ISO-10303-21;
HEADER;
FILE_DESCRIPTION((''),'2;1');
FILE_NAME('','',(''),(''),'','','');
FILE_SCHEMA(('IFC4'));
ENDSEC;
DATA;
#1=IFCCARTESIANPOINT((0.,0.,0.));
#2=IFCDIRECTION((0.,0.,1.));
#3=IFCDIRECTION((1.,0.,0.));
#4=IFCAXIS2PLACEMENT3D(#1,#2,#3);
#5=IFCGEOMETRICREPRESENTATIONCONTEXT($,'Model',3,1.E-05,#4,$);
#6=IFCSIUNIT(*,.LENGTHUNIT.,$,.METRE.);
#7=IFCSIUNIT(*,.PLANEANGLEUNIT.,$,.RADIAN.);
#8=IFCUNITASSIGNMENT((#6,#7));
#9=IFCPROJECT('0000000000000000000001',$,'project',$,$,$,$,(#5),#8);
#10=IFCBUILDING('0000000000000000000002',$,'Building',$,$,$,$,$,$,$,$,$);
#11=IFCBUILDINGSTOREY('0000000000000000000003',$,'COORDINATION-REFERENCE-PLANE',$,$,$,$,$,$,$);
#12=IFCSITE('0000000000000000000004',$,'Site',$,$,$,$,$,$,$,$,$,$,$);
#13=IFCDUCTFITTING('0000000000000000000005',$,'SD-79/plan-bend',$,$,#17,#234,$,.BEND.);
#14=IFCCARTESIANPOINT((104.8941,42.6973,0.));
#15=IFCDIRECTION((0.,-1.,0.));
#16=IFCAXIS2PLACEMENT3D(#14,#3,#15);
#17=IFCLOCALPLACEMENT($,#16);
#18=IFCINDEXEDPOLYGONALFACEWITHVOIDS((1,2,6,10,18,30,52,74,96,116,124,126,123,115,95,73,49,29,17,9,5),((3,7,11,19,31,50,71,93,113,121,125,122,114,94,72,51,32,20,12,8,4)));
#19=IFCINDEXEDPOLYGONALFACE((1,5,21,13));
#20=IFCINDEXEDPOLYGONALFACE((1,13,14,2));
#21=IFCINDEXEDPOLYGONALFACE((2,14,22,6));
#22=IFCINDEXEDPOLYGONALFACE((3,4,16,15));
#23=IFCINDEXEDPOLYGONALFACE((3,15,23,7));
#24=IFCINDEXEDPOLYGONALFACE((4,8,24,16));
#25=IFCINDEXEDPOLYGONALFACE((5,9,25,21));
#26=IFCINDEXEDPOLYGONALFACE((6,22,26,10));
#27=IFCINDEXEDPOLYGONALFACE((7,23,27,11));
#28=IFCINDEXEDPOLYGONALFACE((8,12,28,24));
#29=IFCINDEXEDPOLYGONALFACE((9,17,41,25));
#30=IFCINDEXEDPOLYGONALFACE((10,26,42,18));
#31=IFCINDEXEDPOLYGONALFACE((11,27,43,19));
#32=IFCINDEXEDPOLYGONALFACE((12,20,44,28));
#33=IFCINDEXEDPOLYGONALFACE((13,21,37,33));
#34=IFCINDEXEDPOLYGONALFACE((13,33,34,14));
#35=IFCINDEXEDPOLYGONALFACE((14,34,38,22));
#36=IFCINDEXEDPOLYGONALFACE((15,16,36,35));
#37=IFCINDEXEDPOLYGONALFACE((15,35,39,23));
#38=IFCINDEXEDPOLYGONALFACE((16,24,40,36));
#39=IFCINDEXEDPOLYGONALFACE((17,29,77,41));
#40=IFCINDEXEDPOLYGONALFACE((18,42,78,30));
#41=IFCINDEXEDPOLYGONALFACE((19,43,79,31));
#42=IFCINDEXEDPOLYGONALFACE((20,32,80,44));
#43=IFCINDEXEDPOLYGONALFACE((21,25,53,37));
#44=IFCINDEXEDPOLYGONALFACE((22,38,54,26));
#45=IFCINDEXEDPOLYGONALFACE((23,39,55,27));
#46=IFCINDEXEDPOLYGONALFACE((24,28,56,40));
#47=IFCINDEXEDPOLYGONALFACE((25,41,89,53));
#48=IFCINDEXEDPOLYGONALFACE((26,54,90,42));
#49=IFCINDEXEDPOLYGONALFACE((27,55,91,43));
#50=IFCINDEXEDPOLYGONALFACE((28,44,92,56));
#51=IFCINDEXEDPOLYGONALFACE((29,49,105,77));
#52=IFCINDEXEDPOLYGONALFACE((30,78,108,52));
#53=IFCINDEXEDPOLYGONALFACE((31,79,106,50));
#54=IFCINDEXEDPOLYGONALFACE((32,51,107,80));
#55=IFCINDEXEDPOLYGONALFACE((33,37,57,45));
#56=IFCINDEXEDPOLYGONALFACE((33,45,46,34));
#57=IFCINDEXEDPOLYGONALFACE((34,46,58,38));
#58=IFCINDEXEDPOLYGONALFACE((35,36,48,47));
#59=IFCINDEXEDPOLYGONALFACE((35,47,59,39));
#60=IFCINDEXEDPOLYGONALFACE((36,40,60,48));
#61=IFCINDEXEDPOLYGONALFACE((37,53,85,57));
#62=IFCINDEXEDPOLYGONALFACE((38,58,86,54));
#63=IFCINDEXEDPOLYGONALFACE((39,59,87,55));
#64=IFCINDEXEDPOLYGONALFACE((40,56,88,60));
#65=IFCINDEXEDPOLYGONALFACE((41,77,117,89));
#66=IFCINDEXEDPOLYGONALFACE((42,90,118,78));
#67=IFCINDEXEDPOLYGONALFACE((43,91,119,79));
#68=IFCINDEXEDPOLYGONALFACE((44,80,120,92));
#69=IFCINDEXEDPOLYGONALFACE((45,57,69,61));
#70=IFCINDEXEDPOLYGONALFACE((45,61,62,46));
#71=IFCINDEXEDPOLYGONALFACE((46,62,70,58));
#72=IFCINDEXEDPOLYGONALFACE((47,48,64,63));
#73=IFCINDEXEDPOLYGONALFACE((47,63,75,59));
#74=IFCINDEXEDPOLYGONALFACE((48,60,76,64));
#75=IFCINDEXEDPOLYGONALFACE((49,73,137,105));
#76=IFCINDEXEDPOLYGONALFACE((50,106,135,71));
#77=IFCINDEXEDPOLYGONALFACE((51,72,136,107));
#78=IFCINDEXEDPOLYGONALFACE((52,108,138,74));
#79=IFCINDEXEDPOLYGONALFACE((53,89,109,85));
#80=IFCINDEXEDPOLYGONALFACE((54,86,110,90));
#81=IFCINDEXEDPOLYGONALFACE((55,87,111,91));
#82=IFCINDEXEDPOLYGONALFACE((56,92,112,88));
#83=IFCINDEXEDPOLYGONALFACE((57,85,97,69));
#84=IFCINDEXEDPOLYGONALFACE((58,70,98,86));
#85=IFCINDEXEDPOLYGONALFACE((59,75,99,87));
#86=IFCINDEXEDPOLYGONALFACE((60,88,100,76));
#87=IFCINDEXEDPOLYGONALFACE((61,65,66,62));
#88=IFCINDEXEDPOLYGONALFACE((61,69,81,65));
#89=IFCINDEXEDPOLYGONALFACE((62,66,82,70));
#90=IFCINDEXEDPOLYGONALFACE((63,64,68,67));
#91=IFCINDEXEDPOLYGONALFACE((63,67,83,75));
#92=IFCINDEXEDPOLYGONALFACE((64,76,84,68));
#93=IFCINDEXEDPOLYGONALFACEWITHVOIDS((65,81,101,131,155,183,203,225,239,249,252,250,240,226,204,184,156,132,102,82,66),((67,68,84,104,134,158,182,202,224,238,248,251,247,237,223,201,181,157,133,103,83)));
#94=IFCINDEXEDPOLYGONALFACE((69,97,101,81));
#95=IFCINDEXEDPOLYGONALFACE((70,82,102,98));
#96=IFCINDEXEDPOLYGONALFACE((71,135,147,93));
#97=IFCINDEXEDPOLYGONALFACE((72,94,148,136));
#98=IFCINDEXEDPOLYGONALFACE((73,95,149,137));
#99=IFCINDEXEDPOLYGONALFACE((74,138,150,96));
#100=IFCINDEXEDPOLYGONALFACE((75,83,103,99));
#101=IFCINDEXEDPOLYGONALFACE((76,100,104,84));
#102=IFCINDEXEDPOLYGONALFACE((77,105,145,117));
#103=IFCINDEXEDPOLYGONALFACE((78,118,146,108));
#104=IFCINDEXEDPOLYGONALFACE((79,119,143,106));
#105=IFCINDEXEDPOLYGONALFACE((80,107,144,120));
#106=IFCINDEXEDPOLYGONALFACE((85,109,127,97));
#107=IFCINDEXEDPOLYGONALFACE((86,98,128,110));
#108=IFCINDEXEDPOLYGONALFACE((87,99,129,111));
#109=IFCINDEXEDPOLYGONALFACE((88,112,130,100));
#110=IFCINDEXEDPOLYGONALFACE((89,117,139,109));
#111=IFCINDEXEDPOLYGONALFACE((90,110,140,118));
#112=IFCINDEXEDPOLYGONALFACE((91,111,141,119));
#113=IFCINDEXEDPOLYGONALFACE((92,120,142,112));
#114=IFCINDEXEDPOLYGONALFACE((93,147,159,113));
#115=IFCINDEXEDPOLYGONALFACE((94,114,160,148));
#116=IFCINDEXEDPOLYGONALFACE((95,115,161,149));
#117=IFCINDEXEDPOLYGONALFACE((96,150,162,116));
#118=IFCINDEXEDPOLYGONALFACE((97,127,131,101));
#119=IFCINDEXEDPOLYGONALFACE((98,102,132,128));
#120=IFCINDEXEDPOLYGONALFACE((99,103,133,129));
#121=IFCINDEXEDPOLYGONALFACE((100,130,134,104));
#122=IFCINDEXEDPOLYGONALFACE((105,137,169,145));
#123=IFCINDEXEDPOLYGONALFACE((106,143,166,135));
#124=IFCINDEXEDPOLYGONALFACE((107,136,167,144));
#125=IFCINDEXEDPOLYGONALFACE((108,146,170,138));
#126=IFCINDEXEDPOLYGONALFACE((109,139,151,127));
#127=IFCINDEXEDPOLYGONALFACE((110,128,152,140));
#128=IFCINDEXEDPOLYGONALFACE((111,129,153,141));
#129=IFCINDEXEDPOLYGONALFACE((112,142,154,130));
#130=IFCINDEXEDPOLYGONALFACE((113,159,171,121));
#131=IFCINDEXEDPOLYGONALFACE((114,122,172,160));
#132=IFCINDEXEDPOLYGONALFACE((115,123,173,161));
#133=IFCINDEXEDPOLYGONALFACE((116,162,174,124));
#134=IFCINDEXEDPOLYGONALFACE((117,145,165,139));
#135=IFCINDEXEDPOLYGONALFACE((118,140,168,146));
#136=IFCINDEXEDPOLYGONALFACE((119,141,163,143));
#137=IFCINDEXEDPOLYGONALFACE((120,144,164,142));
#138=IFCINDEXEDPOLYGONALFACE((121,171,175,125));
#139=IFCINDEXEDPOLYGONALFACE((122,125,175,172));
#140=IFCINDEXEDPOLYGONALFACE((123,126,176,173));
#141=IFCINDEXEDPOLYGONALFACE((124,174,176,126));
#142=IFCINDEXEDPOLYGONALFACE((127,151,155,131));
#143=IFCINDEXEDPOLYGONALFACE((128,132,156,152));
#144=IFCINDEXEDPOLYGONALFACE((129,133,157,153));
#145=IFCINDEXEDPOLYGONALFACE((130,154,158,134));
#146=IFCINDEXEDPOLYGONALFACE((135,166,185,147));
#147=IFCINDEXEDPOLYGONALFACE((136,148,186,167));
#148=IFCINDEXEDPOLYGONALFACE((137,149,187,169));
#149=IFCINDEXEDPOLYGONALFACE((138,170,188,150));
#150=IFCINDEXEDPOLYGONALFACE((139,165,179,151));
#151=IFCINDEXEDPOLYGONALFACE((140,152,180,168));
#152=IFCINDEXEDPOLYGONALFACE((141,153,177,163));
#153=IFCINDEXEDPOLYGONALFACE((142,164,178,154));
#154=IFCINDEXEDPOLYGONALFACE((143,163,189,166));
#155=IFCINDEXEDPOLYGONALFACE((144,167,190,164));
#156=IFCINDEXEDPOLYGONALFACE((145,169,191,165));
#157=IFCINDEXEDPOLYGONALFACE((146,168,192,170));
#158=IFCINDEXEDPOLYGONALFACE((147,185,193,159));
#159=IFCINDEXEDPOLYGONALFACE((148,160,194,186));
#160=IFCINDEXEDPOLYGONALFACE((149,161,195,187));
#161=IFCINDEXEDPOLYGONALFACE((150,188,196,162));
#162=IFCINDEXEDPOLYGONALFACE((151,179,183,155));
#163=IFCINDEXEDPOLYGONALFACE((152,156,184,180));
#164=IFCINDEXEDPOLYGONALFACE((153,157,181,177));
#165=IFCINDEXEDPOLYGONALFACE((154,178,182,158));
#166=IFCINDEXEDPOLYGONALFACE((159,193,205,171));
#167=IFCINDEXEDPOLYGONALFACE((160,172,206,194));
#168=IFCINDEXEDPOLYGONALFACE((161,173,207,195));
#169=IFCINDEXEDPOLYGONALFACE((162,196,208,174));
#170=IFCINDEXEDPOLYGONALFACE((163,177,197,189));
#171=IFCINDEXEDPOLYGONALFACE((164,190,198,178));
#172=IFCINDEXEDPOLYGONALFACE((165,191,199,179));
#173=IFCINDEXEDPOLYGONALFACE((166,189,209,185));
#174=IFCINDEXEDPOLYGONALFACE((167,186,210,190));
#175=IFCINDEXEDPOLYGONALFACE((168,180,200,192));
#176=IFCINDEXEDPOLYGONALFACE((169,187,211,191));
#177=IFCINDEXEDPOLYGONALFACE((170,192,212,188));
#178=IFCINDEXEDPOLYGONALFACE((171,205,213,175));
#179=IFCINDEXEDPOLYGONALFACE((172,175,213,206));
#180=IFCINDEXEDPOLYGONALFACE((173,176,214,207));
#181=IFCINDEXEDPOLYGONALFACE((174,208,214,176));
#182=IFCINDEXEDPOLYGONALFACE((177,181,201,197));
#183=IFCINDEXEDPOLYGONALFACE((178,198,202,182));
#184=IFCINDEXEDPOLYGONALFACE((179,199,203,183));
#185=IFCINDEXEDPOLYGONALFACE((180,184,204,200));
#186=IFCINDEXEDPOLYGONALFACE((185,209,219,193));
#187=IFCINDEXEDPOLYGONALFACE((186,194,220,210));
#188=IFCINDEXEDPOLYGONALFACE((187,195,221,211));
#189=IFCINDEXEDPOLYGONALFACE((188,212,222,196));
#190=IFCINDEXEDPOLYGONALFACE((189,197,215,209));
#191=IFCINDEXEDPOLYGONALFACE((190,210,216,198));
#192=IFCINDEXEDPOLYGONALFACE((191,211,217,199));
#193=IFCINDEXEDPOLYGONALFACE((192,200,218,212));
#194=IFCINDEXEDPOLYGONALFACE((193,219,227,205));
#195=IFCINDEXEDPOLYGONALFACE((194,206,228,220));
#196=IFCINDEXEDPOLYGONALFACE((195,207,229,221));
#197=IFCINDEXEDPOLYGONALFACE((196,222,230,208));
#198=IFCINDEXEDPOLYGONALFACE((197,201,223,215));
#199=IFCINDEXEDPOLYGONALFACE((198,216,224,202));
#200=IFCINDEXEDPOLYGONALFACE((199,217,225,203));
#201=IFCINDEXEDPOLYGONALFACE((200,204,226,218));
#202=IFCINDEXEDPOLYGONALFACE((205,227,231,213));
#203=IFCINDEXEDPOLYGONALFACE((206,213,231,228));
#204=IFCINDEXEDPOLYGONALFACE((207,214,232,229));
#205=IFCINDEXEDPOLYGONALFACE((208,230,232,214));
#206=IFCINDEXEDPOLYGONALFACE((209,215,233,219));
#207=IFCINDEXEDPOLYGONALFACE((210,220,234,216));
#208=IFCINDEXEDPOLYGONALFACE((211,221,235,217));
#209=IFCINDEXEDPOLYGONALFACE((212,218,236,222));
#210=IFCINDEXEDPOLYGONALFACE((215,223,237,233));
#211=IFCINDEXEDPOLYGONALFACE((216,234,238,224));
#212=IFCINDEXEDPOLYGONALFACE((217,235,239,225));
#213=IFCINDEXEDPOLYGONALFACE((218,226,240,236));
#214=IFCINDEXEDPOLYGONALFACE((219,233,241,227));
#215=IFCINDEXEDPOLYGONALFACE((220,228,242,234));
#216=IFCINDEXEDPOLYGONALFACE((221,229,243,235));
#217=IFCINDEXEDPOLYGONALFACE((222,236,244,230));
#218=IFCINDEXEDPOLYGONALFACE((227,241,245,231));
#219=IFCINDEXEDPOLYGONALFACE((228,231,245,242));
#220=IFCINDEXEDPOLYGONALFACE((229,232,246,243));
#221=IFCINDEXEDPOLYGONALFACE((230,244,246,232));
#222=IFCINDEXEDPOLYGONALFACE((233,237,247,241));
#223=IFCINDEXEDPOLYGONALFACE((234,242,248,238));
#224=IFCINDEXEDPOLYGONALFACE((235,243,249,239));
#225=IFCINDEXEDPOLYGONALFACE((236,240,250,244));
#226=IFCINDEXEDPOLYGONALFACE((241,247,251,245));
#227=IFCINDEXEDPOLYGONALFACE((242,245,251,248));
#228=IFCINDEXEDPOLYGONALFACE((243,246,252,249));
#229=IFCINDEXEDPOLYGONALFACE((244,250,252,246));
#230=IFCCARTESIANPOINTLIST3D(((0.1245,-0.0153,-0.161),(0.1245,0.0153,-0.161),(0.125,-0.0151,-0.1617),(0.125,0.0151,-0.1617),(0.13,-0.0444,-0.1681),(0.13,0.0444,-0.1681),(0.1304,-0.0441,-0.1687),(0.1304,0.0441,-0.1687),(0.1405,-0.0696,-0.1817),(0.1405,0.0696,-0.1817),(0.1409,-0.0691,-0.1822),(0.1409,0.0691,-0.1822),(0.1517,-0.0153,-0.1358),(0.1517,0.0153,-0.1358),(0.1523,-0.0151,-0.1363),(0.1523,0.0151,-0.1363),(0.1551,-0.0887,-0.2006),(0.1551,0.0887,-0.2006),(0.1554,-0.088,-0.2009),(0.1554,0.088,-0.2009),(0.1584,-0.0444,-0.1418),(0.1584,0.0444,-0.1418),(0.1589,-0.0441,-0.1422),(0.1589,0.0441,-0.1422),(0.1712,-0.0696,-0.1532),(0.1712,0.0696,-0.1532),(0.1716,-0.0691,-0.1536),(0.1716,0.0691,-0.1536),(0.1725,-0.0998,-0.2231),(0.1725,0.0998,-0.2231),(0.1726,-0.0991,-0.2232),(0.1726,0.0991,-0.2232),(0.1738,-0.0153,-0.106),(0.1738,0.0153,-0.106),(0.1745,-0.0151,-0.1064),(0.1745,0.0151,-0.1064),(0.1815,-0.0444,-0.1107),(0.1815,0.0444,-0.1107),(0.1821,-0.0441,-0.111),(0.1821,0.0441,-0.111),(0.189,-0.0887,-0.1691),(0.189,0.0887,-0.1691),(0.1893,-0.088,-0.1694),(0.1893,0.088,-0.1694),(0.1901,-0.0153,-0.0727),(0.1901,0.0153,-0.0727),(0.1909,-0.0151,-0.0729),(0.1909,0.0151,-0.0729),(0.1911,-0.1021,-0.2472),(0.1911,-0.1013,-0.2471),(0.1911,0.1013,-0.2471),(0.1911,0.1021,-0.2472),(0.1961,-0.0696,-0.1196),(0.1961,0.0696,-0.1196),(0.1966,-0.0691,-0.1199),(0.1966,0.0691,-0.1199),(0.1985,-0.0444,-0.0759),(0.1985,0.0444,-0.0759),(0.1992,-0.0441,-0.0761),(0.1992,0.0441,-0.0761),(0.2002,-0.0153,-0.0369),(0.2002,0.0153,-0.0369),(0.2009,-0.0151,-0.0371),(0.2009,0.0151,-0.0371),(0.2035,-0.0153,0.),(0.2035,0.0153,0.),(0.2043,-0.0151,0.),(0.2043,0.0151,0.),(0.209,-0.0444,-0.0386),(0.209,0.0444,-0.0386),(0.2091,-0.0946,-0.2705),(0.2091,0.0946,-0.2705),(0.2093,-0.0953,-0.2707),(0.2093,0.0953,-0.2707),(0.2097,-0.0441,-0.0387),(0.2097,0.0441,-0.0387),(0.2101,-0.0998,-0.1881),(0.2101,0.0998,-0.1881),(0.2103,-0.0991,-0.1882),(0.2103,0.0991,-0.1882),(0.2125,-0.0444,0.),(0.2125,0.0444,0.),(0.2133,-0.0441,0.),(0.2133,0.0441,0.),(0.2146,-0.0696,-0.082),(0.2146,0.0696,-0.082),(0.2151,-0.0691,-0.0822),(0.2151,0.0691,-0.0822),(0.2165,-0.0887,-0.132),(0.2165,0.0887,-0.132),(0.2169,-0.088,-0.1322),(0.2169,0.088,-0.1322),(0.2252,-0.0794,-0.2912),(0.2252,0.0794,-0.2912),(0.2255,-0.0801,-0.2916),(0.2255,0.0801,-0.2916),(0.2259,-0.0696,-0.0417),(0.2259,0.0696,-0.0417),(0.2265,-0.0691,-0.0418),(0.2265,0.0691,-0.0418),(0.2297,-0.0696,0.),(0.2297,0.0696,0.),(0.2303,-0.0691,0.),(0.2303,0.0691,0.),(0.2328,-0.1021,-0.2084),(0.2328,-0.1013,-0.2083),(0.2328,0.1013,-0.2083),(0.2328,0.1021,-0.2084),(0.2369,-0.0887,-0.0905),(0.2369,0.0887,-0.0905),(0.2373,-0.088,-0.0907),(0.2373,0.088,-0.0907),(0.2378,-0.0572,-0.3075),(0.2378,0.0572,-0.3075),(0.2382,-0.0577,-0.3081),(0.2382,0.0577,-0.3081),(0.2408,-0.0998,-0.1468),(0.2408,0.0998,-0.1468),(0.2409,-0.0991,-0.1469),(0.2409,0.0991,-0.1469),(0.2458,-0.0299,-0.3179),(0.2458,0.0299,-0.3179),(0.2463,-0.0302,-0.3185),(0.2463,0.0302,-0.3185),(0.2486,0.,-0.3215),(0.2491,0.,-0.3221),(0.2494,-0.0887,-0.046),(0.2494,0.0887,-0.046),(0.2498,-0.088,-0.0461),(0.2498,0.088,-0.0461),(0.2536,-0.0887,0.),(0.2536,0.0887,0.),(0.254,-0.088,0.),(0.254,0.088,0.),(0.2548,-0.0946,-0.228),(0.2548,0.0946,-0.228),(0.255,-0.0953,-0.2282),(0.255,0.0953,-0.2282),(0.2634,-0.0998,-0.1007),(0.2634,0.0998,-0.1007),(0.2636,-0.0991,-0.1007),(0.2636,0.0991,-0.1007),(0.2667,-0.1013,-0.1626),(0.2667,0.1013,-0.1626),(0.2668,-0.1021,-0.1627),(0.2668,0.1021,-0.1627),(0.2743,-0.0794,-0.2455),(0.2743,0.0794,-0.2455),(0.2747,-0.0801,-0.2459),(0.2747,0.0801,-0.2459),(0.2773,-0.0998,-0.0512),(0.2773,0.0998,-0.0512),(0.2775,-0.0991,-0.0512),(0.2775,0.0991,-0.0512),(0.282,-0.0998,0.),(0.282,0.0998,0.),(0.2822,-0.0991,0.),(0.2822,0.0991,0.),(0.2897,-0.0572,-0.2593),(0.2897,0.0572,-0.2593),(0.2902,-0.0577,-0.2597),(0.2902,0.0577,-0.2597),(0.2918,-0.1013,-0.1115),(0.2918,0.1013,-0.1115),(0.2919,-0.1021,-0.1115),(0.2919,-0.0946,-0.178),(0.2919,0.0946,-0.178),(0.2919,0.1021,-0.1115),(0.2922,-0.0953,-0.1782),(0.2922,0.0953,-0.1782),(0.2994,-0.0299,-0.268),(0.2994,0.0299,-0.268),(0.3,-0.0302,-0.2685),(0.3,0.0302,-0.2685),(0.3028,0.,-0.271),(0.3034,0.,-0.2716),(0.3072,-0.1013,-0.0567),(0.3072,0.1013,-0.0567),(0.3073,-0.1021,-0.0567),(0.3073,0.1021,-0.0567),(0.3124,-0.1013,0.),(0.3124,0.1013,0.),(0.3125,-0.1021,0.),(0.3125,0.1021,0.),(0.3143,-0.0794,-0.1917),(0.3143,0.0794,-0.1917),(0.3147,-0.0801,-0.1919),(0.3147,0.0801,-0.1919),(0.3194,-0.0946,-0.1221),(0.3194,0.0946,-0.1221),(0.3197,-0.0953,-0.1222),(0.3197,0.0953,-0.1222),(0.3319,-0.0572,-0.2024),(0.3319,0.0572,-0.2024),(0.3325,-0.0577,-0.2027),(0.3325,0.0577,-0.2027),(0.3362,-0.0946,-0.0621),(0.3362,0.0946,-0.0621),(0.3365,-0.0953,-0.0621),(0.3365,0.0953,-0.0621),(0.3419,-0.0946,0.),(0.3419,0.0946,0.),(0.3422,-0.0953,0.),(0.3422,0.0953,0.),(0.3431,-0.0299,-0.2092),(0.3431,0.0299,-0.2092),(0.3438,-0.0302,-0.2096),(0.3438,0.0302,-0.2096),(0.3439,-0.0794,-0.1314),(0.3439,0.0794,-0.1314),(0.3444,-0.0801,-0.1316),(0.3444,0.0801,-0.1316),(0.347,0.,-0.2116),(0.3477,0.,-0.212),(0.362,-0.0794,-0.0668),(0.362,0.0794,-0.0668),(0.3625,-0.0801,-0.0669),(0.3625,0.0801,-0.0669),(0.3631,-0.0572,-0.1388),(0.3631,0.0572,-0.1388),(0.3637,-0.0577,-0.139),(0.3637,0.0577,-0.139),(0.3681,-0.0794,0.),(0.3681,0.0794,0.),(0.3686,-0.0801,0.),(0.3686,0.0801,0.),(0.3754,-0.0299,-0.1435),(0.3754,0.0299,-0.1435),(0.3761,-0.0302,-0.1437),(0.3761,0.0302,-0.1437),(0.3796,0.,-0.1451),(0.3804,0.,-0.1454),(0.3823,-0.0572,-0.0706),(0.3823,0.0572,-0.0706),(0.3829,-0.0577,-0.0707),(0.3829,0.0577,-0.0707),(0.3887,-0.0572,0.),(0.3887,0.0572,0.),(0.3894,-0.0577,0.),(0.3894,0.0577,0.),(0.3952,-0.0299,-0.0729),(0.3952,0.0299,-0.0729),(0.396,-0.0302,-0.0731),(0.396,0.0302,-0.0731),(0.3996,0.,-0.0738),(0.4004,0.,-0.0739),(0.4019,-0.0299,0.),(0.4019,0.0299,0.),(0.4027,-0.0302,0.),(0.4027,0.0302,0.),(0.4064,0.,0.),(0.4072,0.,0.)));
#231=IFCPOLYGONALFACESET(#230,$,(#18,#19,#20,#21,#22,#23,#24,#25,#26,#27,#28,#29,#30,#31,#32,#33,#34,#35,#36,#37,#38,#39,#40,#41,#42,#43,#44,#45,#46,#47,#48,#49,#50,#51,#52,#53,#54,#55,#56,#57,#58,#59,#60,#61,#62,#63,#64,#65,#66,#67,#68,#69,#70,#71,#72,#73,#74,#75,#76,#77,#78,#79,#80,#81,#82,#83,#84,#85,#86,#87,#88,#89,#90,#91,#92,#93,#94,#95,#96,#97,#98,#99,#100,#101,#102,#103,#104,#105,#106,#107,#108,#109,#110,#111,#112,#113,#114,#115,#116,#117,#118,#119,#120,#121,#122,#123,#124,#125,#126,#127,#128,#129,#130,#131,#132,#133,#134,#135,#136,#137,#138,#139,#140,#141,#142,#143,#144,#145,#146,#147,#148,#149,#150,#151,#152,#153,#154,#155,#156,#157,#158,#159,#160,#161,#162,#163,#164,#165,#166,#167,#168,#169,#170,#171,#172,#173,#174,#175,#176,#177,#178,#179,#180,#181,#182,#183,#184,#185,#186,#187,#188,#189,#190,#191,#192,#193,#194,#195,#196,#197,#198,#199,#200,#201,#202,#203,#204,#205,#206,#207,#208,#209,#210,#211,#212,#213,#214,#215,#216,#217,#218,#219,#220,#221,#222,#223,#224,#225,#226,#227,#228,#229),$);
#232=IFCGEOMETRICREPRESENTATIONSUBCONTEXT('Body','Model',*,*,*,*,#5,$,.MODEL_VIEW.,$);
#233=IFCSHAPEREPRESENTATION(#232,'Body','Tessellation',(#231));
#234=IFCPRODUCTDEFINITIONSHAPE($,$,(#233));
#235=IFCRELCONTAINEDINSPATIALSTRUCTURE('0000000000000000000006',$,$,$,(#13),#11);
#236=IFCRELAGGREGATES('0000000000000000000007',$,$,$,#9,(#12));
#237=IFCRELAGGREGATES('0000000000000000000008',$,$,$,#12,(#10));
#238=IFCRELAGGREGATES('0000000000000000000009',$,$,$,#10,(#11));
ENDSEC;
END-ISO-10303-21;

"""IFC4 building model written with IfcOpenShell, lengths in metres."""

from ifc_helpers import new_model, entity, si_unit, frame, origin_with_axes, place, context, subcontext, project, spatial, element, save


model = new_model("IFC4")

# Units and contexts
model_context_1 = context("Model", 3, precision=1e-05, world=origin_with_axes())
body_context_1 = subcontext(model_context_1, "Body", "Model", "MODEL_VIEW")
ifc_project = project(units=[si_unit("LENGTHUNIT", "METRE"), si_unit("PLANEANGLEUNIT", "RADIAN")], contexts=[model_context_1])

# Site, building, storey
site = spatial("IfcSite", under=ifc_project, Name="Site")
building = spatial("IfcBuilding", under=site, Name="Building")
storey = spatial("IfcBuildingStorey", under=building, Name="COORDINATION-REFERENCE-PLANE")

# Duct fitting
duct_fitting_1_placement = place(None, frame((104.8941, 42.6973, 0.0), z_axis=(1.0, 0.0, 0.0), x_axis=(0.0, -1.0, 0.0)))
element("IfcDuctFitting", 1, at=duct_fitting_1_placement, inside=storey, Name="SD-79/plan-bend", PredefinedType="BEND", context=body_context_1, shape_type="SweptSolid", body=[
    entity("IfcRevolvedAreaSolid", entity("IfcCircleHollowProfileDef", "AREA", None, entity("IfcAxis2Placement2D", entity("IfcCartesianPoint", [0.3048, 0.0])), 0.1024, 0.0008), entity("IfcAxis2Placement3D", entity("IfcCartesianPoint", [0.0, 0.0, 0.0]), entity("IfcDirection", [0.0, 0.0, 1.0]), entity("IfcDirection", [1.0, 0.0, 0.0])), entity("IfcAxis1Placement", entity("IfcCartesianPoint", [0.0, 0.0, 0.0]), entity("IfcDirection", [0.0, 1.0, 0.0])), 0.912619),
])

save(model, "model.ifc")
